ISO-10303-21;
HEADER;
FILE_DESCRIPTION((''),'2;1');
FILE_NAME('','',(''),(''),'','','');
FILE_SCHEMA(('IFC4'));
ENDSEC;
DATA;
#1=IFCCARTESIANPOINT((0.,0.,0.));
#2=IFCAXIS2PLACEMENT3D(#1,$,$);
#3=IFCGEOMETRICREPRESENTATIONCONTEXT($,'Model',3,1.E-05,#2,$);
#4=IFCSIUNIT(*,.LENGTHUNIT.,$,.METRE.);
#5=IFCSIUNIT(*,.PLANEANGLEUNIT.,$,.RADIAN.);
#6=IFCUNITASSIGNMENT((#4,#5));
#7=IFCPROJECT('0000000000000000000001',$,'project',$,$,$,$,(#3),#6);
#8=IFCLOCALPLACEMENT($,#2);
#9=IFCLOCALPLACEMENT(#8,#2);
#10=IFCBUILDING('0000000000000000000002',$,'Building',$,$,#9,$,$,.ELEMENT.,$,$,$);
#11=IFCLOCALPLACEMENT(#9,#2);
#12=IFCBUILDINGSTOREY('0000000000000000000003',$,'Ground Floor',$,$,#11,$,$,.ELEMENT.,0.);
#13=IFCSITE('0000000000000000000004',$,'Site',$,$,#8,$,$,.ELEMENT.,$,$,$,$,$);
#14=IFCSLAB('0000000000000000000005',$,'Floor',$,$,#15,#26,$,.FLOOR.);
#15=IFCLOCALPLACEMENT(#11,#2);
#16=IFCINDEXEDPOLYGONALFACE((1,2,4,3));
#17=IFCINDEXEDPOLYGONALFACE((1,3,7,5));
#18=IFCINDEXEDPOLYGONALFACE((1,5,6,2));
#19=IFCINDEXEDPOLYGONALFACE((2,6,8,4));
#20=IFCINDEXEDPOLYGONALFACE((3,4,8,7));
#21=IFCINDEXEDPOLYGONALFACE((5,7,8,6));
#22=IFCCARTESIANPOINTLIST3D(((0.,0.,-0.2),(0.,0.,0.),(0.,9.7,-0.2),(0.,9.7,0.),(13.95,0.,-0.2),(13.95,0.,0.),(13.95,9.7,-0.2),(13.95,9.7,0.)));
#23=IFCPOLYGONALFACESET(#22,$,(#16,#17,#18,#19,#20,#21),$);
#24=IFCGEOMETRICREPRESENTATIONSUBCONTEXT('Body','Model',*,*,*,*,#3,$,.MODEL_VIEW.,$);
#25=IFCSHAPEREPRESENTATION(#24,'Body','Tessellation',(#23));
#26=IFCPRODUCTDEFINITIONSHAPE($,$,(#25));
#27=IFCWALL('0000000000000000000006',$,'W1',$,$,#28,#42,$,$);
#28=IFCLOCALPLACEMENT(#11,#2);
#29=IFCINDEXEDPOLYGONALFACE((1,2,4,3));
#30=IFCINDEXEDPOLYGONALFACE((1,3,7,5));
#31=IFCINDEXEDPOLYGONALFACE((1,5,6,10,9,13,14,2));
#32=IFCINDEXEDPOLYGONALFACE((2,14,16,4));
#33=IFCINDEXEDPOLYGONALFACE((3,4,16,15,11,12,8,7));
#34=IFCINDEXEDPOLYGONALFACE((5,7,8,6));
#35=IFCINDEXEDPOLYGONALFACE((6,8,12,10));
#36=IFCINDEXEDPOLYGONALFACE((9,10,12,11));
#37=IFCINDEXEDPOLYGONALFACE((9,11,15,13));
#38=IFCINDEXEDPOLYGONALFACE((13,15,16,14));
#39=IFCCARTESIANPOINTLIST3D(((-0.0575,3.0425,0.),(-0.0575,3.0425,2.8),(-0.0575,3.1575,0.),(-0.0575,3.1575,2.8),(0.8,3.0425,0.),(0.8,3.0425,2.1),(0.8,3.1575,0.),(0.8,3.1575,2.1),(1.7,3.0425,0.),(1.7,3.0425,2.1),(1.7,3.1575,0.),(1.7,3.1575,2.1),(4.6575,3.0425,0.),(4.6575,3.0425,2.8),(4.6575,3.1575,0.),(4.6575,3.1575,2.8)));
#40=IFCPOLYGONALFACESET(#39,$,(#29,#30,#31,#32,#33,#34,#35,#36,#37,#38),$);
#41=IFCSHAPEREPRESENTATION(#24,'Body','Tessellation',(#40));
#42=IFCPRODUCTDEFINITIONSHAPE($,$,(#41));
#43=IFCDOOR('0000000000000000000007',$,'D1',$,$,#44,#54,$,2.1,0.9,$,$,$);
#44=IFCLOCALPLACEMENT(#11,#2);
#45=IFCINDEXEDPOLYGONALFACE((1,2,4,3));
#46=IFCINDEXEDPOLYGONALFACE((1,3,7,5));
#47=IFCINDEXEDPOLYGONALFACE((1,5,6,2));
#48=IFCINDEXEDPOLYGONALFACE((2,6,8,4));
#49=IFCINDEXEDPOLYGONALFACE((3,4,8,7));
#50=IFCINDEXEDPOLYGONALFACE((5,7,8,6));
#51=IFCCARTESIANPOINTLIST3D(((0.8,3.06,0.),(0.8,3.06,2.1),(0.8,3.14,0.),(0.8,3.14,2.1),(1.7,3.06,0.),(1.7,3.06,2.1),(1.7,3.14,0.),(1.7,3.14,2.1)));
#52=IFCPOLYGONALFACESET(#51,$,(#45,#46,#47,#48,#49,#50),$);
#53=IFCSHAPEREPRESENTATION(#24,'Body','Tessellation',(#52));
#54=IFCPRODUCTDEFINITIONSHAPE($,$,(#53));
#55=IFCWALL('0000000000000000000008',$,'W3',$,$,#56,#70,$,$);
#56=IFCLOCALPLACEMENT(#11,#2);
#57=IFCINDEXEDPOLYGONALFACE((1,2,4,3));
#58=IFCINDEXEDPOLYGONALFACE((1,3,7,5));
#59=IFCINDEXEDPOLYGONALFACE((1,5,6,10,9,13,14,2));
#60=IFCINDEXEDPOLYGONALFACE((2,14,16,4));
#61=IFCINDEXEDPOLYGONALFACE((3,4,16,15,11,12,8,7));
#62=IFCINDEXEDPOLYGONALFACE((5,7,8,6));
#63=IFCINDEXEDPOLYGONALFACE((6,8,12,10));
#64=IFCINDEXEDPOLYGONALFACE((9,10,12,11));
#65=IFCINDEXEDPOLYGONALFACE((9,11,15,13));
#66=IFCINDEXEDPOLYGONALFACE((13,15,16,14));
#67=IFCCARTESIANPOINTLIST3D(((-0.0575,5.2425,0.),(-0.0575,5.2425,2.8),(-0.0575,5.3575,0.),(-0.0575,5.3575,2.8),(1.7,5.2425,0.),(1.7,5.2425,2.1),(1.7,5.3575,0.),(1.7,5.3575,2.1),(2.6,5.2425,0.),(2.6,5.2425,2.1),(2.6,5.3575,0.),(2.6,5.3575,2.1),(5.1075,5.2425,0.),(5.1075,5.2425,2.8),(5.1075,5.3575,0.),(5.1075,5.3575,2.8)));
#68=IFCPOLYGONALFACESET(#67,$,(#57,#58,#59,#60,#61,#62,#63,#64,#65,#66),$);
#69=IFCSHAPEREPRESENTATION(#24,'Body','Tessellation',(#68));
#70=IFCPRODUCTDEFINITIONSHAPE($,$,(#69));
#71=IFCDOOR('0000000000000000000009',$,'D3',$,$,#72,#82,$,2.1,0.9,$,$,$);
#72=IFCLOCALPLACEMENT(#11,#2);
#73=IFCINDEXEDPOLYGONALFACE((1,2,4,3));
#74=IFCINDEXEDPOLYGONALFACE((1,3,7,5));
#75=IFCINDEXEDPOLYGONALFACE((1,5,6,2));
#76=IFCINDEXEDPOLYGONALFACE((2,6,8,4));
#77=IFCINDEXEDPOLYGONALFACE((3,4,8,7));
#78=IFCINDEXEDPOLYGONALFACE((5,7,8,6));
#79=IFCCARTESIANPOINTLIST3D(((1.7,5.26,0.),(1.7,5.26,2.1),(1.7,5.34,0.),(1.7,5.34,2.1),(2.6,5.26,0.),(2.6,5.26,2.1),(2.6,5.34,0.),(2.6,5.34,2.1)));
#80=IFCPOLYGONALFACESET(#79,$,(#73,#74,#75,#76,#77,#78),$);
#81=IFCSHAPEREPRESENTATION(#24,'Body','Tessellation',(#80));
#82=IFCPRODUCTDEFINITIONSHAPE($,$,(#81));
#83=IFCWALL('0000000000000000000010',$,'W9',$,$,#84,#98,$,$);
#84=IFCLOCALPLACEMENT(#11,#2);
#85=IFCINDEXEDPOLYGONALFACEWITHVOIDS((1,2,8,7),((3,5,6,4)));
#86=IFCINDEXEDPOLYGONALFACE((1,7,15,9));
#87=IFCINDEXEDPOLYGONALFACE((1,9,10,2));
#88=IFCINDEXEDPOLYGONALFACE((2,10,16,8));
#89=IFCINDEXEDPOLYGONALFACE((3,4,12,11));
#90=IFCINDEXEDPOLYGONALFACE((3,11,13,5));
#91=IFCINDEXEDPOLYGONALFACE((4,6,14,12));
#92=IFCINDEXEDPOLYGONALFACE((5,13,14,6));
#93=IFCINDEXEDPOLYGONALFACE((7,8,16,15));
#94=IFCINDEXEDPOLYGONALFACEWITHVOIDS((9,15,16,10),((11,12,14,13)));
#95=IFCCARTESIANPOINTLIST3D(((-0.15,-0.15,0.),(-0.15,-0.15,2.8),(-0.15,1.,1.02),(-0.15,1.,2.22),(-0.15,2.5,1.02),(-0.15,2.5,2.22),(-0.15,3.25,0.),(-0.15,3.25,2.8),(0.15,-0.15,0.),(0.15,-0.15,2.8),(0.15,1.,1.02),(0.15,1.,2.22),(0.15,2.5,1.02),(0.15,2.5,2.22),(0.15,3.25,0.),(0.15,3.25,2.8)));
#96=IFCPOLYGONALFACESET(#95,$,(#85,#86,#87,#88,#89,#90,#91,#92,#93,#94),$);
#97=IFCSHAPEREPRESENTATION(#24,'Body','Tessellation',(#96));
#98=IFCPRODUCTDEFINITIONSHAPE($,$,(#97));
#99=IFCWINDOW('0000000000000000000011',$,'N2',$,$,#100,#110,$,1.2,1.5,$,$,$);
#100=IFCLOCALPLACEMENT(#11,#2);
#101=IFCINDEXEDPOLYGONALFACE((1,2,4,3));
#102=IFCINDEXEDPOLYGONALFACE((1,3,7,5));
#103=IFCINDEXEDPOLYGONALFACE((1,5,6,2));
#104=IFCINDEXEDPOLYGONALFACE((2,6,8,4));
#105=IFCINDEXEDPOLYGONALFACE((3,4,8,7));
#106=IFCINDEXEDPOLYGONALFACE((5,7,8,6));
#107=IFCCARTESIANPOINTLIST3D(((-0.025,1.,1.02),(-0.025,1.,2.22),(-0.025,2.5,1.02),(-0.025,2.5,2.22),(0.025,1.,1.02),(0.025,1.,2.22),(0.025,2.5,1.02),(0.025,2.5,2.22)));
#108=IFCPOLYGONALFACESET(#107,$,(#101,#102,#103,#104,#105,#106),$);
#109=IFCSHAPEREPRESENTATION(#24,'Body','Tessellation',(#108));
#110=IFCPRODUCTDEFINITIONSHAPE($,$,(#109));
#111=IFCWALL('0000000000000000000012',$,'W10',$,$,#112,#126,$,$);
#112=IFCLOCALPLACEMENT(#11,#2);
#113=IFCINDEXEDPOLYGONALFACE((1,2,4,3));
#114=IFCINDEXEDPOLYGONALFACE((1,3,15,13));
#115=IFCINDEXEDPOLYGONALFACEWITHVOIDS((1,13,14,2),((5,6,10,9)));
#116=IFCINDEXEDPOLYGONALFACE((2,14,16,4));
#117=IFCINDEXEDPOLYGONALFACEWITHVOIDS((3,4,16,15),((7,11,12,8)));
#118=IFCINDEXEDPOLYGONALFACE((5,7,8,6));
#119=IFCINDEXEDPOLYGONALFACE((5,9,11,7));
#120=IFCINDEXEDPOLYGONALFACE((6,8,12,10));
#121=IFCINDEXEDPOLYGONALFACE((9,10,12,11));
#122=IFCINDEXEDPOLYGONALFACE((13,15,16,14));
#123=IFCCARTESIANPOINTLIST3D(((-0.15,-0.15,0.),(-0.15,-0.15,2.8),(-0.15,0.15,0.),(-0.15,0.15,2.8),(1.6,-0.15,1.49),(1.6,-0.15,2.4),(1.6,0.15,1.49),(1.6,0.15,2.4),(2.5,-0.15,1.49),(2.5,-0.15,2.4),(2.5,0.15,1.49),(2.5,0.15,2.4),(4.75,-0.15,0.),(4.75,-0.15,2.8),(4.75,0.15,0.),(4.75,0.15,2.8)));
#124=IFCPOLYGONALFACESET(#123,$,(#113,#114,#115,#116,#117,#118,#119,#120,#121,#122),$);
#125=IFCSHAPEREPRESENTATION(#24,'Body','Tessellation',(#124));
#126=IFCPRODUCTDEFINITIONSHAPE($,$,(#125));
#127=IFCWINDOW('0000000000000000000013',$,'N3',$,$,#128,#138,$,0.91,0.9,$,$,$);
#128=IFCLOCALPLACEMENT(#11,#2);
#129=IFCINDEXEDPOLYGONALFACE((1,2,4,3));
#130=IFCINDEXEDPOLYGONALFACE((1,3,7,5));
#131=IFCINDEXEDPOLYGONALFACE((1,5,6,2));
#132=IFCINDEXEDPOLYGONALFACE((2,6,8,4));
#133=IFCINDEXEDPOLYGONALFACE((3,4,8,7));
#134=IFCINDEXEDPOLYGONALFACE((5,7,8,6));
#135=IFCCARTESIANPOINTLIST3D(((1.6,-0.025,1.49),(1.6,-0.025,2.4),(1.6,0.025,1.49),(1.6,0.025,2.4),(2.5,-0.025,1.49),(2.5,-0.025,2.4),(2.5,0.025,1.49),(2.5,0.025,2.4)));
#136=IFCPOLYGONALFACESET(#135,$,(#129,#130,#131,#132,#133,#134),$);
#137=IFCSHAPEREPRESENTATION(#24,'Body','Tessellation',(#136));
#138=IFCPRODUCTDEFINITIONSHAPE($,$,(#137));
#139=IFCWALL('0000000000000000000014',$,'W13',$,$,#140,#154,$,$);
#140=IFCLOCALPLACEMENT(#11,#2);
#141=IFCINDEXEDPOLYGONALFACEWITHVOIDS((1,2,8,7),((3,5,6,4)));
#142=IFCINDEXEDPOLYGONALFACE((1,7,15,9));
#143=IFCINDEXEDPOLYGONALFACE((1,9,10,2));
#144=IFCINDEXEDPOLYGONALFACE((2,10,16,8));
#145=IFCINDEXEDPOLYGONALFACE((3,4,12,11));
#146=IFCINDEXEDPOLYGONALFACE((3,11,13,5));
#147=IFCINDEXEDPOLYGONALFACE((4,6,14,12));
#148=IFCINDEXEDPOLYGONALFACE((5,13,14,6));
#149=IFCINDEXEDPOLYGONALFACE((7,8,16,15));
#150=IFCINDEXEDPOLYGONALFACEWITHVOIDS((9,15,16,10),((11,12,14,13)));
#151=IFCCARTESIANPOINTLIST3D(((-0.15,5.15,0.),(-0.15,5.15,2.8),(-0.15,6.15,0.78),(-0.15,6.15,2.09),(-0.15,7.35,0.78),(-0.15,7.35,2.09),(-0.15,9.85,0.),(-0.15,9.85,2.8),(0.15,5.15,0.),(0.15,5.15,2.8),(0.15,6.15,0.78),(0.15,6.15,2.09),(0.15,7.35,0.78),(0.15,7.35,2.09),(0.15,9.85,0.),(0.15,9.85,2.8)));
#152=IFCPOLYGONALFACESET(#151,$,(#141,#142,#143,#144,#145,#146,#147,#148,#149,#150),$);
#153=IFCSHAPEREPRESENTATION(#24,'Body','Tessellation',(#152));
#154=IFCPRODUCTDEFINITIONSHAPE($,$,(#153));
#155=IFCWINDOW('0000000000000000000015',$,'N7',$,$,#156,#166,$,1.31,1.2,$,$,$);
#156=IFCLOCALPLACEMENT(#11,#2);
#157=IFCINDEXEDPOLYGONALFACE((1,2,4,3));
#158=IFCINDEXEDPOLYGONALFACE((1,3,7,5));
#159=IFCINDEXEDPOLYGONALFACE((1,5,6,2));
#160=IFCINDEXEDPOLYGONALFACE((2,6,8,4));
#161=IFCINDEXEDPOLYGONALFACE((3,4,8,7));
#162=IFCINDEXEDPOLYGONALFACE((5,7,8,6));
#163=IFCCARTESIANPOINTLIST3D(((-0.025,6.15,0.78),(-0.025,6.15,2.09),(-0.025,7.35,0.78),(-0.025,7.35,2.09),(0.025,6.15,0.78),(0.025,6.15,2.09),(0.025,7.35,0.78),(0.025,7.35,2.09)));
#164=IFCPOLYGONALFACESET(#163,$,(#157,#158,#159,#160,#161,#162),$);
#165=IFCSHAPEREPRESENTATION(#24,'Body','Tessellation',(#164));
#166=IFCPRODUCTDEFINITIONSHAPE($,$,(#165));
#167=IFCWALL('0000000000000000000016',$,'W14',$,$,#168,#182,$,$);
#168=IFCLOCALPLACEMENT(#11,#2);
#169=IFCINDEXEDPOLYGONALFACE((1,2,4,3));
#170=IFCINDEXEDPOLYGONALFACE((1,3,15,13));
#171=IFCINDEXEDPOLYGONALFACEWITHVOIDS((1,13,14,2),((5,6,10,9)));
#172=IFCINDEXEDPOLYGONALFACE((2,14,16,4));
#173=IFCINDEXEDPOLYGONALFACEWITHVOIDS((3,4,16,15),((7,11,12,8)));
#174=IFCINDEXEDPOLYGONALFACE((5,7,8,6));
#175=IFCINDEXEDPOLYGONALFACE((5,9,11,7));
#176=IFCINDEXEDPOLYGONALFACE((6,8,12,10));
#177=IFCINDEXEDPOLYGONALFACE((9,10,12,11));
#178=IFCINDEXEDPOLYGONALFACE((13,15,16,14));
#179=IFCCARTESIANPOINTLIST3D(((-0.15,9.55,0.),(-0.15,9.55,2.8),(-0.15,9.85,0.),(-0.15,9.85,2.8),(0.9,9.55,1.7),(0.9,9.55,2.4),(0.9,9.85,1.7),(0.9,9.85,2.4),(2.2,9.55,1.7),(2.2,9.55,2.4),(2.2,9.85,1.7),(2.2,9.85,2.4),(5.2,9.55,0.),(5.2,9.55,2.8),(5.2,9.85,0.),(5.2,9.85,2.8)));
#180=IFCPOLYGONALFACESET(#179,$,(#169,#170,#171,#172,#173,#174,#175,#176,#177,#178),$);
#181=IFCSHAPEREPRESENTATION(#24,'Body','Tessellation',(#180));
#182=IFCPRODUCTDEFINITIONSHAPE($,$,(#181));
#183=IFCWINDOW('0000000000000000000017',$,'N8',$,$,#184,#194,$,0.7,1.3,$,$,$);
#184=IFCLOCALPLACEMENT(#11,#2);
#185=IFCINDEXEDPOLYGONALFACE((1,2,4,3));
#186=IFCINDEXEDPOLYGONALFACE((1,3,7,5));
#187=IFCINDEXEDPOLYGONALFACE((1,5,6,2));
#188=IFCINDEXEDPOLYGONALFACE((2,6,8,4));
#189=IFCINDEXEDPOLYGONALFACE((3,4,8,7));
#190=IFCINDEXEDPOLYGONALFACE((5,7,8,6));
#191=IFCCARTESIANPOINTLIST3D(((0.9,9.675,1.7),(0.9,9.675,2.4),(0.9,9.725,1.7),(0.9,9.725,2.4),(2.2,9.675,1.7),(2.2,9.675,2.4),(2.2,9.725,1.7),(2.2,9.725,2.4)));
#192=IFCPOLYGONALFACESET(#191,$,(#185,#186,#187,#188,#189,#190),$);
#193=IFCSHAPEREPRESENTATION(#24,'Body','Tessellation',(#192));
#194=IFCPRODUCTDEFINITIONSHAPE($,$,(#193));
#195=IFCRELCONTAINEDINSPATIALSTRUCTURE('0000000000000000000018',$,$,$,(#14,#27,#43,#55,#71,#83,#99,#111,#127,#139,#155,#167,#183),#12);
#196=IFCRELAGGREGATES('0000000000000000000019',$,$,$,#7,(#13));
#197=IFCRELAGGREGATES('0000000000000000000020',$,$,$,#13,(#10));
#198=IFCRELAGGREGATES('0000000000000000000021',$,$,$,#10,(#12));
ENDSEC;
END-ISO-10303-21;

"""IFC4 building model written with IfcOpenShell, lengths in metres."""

from ifc_helpers import new_model, si_unit, frame, frame_2d, origin, origin_2d, place, context, subcontext, project, spatial, polyline, rectangle, outline, extrude, element, fill, save


model = new_model("IFC4")

# Units and contexts
model_context = context("Model", 3, precision=1e-05, world=origin())
body_context = subcontext(model_context, "Body", "Model", "MODEL_VIEW")
ifc_project = project(units=[si_unit("LENGTHUNIT", "METRE"), si_unit("PLANEANGLEUNIT", "RADIAN")], contexts=[model_context])

# Site, building, storey
site_placement = place(None, origin())
site = spatial("IfcSite", under=ifc_project, at=site_placement, Name="Site", CompositionType="ELEMENT")
building_placement = place(site_placement, origin())
building = spatial("IfcBuilding", under=site, at=building_placement, Name="Building", CompositionType="ELEMENT")
storey_placement = place(building_placement, origin())
storey = spatial("IfcBuildingStorey", under=building, at=storey_placement, Name="Ground Floor", CompositionType="ELEMENT", Elevation=0.0)

# Slab
slab_placement = place(storey_placement, origin())
element("IfcSlab", 1, at=slab_placement, inside=storey, Name="Floor", PredefinedType="FLOOR", context=body_context, shape_type="SweptSolid", body=[
    extrude(outline(polyline([(0.0, 0.0), (13.95, 0.0), (13.95, 9.7), (0.0, 9.7), (0.0, 0.0)])), origin(), (0.0, 0.0, -1.0), 0.2),
])

# Walls, openings, doors
wall_1_placement = place(storey_placement, frame((0.0, 3.1, 0.0), x_axis=(1.0, 0.0, 0.0)))
wall_1 = element("IfcWall", 2, at=wall_1_placement, inside=storey, Name="W1", context=body_context, shape_type="SweptSolid", body=[
    extrude(rectangle(XDim=4.715, YDim=0.115, at=frame_2d((2.3, 0.0))), origin(), (0.0, 0.0, 1.0), 2.8),
])
opening_1_placement = place(wall_1_placement, frame((1.25, 0.0, 0.0)))
opening_1 = element("IfcOpeningElement", 3, at=opening_1_placement, cuts=wall_1, context=body_context, shape_type="SweptSolid", body=[
    extrude(rectangle(XDim=0.9, YDim=0.215, at=origin_2d()), origin(), (0.0, 0.0, 1.0), 2.1),
])
door_1_placement = place(opening_1_placement, origin())
door_1 = element("IfcDoor", 4, at=door_1_placement, inside=storey, Name="D1", OverallHeight=2.1, OverallWidth=0.9, context=body_context, shape_type="SweptSolid", body=[
    extrude(rectangle(XDim=0.9, YDim=0.08, at=origin_2d()), origin(), (0.0, 0.0, 1.0), 2.1),
])
fill(opening_1, door_1)
wall_2_placement = place(storey_placement, frame((0.0, 5.3, 0.0), x_axis=(1.0, 0.0, 0.0)))
wall_2 = element("IfcWall", 5, at=wall_2_placement, inside=storey, Name="W3", context=body_context, shape_type="SweptSolid", body=[
    extrude(rectangle(XDim=5.165, YDim=0.115, at=frame_2d((2.525, 0.0))), origin(), (0.0, 0.0, 1.0), 2.8),
])
opening_2_placement = place(wall_2_placement, frame((2.15, 0.0, 0.0)))
opening_2 = element("IfcOpeningElement", 6, at=opening_2_placement, cuts=wall_2, context=body_context, shape_type="SweptSolid", body=[
    extrude(rectangle(XDim=0.9, YDim=0.215, at=origin_2d()), origin(), (0.0, 0.0, 1.0), 2.1),
])
door_2_placement = place(opening_2_placement, origin())
door_2 = element("IfcDoor", 7, at=door_2_placement, inside=storey, Name="D3", OverallHeight=2.1, OverallWidth=0.9, context=body_context, shape_type="SweptSolid", body=[
    extrude(rectangle(XDim=0.9, YDim=0.08, at=origin_2d()), origin(), (0.0, 0.0, 1.0), 2.1),
])
fill(opening_2, door_2)

# Walls, openings, windows
wall_3_placement = place(storey_placement, frame((0.0, 0.0, 0.0), x_axis=(0.0, 1.0, 0.0)))
wall_3 = element("IfcWall", 8, at=wall_3_placement, inside=storey, Name="W9", context=body_context, shape_type="SweptSolid", body=[
    extrude(rectangle(XDim=3.4, YDim=0.3, at=frame_2d((1.55, 0.0))), origin(), (0.0, 0.0, 1.0), 2.8),
])
opening_3_placement = place(wall_3_placement, frame((1.75, 0.0, 1.02)))
opening_3 = element("IfcOpeningElement", 9, at=opening_3_placement, cuts=wall_3, context=body_context, shape_type="SweptSolid", body=[
    extrude(rectangle(XDim=1.5, YDim=0.4, at=origin_2d()), origin(), (0.0, 0.0, 1.0), 1.2),
])
window_1_placement = place(opening_3_placement, origin())
window_1 = element("IfcWindow", 10, at=window_1_placement, inside=storey, Name="N2", OverallHeight=1.2, OverallWidth=1.5, context=body_context, shape_type="SweptSolid", body=[
    extrude(rectangle(XDim=1.5, YDim=0.05, at=origin_2d()), origin(), (0.0, 0.0, 1.0), 1.2),
])
fill(opening_3, window_1)
wall_4_placement = place(storey_placement, frame((0.0, 0.0, 0.0), x_axis=(1.0, 0.0, 0.0)))
wall_4 = element("IfcWall", 11, at=wall_4_placement, inside=storey, Name="W10", context=body_context, shape_type="SweptSolid", body=[
    extrude(rectangle(XDim=4.9, YDim=0.3, at=frame_2d((2.3, 0.0))), origin(), (0.0, 0.0, 1.0), 2.8),
])
opening_4_placement = place(wall_4_placement, frame((2.05, 0.0, 1.49)))
opening_4 = element("IfcOpeningElement", 12, at=opening_4_placement, cuts=wall_4, context=body_context, shape_type="SweptSolid", body=[
    extrude(rectangle(XDim=0.9, YDim=0.4, at=origin_2d()), origin(), (0.0, 0.0, 1.0), 0.91),
])
window_2_placement = place(opening_4_placement, origin())
window_2 = element("IfcWindow", 13, at=window_2_placement, inside=storey, Name="N3", OverallHeight=0.91, OverallWidth=0.9, context=body_context, shape_type="SweptSolid", body=[
    extrude(rectangle(XDim=0.9, YDim=0.05, at=origin_2d()), origin(), (0.0, 0.0, 1.0), 0.91),
])
fill(opening_4, window_2)
wall_5_placement = place(storey_placement, frame((0.0, 5.3, 0.0), x_axis=(0.0, 1.0, 0.0)))
wall_5 = element("IfcWall", 14, at=wall_5_placement, inside=storey, Name="W13", context=body_context, shape_type="SweptSolid", body=[
    extrude(rectangle(XDim=4.7, YDim=0.3, at=frame_2d((2.2, 0.0))), origin(), (0.0, 0.0, 1.0), 2.8),
])
opening_5_placement = place(wall_5_placement, frame((1.45, 0.0, 0.78)))
opening_5 = element("IfcOpeningElement", 15, at=opening_5_placement, cuts=wall_5, context=body_context, shape_type="SweptSolid", body=[
    extrude(rectangle(XDim=1.2, YDim=0.4, at=origin_2d()), origin(), (0.0, 0.0, 1.0), 1.31),
])
window_3_placement = place(opening_5_placement, origin())
window_3 = element("IfcWindow", 16, at=window_3_placement, inside=storey, Name="N7", OverallHeight=1.31, OverallWidth=1.2, context=body_context, shape_type="SweptSolid", body=[
    extrude(rectangle(XDim=1.2, YDim=0.05, at=origin_2d()), origin(), (0.0, 0.0, 1.0), 1.31),
])
fill(opening_5, window_3)
wall_6_placement = place(storey_placement, frame((0.0, 9.7, 0.0), x_axis=(1.0, 0.0, 0.0)))
wall_6 = element("IfcWall", 17, at=wall_6_placement, inside=storey, Name="W14", context=body_context, shape_type="SweptSolid", body=[
    extrude(rectangle(XDim=5.35, YDim=0.3, at=frame_2d((2.525, 0.0))), origin(), (0.0, 0.0, 1.0), 2.8),
])
opening_6_placement = place(wall_6_placement, frame((1.55, 0.0, 1.7)))
opening_6 = element("IfcOpeningElement", 18, at=opening_6_placement, cuts=wall_6, context=body_context, shape_type="SweptSolid", body=[
    extrude(rectangle(XDim=1.3, YDim=0.4, at=origin_2d()), origin(), (0.0, 0.0, 1.0), 0.7),
])
window_4_placement = place(opening_6_placement, origin())
window_4 = element("IfcWindow", 19, at=window_4_placement, inside=storey, Name="N8", OverallHeight=0.7, OverallWidth=1.3, context=body_context, shape_type="SweptSolid", body=[
    extrude(rectangle(XDim=1.3, YDim=0.05, at=origin_2d()), origin(), (0.0, 0.0, 1.0), 0.7),
])
fill(opening_6, window_4)

save(model, "model.ifc")
